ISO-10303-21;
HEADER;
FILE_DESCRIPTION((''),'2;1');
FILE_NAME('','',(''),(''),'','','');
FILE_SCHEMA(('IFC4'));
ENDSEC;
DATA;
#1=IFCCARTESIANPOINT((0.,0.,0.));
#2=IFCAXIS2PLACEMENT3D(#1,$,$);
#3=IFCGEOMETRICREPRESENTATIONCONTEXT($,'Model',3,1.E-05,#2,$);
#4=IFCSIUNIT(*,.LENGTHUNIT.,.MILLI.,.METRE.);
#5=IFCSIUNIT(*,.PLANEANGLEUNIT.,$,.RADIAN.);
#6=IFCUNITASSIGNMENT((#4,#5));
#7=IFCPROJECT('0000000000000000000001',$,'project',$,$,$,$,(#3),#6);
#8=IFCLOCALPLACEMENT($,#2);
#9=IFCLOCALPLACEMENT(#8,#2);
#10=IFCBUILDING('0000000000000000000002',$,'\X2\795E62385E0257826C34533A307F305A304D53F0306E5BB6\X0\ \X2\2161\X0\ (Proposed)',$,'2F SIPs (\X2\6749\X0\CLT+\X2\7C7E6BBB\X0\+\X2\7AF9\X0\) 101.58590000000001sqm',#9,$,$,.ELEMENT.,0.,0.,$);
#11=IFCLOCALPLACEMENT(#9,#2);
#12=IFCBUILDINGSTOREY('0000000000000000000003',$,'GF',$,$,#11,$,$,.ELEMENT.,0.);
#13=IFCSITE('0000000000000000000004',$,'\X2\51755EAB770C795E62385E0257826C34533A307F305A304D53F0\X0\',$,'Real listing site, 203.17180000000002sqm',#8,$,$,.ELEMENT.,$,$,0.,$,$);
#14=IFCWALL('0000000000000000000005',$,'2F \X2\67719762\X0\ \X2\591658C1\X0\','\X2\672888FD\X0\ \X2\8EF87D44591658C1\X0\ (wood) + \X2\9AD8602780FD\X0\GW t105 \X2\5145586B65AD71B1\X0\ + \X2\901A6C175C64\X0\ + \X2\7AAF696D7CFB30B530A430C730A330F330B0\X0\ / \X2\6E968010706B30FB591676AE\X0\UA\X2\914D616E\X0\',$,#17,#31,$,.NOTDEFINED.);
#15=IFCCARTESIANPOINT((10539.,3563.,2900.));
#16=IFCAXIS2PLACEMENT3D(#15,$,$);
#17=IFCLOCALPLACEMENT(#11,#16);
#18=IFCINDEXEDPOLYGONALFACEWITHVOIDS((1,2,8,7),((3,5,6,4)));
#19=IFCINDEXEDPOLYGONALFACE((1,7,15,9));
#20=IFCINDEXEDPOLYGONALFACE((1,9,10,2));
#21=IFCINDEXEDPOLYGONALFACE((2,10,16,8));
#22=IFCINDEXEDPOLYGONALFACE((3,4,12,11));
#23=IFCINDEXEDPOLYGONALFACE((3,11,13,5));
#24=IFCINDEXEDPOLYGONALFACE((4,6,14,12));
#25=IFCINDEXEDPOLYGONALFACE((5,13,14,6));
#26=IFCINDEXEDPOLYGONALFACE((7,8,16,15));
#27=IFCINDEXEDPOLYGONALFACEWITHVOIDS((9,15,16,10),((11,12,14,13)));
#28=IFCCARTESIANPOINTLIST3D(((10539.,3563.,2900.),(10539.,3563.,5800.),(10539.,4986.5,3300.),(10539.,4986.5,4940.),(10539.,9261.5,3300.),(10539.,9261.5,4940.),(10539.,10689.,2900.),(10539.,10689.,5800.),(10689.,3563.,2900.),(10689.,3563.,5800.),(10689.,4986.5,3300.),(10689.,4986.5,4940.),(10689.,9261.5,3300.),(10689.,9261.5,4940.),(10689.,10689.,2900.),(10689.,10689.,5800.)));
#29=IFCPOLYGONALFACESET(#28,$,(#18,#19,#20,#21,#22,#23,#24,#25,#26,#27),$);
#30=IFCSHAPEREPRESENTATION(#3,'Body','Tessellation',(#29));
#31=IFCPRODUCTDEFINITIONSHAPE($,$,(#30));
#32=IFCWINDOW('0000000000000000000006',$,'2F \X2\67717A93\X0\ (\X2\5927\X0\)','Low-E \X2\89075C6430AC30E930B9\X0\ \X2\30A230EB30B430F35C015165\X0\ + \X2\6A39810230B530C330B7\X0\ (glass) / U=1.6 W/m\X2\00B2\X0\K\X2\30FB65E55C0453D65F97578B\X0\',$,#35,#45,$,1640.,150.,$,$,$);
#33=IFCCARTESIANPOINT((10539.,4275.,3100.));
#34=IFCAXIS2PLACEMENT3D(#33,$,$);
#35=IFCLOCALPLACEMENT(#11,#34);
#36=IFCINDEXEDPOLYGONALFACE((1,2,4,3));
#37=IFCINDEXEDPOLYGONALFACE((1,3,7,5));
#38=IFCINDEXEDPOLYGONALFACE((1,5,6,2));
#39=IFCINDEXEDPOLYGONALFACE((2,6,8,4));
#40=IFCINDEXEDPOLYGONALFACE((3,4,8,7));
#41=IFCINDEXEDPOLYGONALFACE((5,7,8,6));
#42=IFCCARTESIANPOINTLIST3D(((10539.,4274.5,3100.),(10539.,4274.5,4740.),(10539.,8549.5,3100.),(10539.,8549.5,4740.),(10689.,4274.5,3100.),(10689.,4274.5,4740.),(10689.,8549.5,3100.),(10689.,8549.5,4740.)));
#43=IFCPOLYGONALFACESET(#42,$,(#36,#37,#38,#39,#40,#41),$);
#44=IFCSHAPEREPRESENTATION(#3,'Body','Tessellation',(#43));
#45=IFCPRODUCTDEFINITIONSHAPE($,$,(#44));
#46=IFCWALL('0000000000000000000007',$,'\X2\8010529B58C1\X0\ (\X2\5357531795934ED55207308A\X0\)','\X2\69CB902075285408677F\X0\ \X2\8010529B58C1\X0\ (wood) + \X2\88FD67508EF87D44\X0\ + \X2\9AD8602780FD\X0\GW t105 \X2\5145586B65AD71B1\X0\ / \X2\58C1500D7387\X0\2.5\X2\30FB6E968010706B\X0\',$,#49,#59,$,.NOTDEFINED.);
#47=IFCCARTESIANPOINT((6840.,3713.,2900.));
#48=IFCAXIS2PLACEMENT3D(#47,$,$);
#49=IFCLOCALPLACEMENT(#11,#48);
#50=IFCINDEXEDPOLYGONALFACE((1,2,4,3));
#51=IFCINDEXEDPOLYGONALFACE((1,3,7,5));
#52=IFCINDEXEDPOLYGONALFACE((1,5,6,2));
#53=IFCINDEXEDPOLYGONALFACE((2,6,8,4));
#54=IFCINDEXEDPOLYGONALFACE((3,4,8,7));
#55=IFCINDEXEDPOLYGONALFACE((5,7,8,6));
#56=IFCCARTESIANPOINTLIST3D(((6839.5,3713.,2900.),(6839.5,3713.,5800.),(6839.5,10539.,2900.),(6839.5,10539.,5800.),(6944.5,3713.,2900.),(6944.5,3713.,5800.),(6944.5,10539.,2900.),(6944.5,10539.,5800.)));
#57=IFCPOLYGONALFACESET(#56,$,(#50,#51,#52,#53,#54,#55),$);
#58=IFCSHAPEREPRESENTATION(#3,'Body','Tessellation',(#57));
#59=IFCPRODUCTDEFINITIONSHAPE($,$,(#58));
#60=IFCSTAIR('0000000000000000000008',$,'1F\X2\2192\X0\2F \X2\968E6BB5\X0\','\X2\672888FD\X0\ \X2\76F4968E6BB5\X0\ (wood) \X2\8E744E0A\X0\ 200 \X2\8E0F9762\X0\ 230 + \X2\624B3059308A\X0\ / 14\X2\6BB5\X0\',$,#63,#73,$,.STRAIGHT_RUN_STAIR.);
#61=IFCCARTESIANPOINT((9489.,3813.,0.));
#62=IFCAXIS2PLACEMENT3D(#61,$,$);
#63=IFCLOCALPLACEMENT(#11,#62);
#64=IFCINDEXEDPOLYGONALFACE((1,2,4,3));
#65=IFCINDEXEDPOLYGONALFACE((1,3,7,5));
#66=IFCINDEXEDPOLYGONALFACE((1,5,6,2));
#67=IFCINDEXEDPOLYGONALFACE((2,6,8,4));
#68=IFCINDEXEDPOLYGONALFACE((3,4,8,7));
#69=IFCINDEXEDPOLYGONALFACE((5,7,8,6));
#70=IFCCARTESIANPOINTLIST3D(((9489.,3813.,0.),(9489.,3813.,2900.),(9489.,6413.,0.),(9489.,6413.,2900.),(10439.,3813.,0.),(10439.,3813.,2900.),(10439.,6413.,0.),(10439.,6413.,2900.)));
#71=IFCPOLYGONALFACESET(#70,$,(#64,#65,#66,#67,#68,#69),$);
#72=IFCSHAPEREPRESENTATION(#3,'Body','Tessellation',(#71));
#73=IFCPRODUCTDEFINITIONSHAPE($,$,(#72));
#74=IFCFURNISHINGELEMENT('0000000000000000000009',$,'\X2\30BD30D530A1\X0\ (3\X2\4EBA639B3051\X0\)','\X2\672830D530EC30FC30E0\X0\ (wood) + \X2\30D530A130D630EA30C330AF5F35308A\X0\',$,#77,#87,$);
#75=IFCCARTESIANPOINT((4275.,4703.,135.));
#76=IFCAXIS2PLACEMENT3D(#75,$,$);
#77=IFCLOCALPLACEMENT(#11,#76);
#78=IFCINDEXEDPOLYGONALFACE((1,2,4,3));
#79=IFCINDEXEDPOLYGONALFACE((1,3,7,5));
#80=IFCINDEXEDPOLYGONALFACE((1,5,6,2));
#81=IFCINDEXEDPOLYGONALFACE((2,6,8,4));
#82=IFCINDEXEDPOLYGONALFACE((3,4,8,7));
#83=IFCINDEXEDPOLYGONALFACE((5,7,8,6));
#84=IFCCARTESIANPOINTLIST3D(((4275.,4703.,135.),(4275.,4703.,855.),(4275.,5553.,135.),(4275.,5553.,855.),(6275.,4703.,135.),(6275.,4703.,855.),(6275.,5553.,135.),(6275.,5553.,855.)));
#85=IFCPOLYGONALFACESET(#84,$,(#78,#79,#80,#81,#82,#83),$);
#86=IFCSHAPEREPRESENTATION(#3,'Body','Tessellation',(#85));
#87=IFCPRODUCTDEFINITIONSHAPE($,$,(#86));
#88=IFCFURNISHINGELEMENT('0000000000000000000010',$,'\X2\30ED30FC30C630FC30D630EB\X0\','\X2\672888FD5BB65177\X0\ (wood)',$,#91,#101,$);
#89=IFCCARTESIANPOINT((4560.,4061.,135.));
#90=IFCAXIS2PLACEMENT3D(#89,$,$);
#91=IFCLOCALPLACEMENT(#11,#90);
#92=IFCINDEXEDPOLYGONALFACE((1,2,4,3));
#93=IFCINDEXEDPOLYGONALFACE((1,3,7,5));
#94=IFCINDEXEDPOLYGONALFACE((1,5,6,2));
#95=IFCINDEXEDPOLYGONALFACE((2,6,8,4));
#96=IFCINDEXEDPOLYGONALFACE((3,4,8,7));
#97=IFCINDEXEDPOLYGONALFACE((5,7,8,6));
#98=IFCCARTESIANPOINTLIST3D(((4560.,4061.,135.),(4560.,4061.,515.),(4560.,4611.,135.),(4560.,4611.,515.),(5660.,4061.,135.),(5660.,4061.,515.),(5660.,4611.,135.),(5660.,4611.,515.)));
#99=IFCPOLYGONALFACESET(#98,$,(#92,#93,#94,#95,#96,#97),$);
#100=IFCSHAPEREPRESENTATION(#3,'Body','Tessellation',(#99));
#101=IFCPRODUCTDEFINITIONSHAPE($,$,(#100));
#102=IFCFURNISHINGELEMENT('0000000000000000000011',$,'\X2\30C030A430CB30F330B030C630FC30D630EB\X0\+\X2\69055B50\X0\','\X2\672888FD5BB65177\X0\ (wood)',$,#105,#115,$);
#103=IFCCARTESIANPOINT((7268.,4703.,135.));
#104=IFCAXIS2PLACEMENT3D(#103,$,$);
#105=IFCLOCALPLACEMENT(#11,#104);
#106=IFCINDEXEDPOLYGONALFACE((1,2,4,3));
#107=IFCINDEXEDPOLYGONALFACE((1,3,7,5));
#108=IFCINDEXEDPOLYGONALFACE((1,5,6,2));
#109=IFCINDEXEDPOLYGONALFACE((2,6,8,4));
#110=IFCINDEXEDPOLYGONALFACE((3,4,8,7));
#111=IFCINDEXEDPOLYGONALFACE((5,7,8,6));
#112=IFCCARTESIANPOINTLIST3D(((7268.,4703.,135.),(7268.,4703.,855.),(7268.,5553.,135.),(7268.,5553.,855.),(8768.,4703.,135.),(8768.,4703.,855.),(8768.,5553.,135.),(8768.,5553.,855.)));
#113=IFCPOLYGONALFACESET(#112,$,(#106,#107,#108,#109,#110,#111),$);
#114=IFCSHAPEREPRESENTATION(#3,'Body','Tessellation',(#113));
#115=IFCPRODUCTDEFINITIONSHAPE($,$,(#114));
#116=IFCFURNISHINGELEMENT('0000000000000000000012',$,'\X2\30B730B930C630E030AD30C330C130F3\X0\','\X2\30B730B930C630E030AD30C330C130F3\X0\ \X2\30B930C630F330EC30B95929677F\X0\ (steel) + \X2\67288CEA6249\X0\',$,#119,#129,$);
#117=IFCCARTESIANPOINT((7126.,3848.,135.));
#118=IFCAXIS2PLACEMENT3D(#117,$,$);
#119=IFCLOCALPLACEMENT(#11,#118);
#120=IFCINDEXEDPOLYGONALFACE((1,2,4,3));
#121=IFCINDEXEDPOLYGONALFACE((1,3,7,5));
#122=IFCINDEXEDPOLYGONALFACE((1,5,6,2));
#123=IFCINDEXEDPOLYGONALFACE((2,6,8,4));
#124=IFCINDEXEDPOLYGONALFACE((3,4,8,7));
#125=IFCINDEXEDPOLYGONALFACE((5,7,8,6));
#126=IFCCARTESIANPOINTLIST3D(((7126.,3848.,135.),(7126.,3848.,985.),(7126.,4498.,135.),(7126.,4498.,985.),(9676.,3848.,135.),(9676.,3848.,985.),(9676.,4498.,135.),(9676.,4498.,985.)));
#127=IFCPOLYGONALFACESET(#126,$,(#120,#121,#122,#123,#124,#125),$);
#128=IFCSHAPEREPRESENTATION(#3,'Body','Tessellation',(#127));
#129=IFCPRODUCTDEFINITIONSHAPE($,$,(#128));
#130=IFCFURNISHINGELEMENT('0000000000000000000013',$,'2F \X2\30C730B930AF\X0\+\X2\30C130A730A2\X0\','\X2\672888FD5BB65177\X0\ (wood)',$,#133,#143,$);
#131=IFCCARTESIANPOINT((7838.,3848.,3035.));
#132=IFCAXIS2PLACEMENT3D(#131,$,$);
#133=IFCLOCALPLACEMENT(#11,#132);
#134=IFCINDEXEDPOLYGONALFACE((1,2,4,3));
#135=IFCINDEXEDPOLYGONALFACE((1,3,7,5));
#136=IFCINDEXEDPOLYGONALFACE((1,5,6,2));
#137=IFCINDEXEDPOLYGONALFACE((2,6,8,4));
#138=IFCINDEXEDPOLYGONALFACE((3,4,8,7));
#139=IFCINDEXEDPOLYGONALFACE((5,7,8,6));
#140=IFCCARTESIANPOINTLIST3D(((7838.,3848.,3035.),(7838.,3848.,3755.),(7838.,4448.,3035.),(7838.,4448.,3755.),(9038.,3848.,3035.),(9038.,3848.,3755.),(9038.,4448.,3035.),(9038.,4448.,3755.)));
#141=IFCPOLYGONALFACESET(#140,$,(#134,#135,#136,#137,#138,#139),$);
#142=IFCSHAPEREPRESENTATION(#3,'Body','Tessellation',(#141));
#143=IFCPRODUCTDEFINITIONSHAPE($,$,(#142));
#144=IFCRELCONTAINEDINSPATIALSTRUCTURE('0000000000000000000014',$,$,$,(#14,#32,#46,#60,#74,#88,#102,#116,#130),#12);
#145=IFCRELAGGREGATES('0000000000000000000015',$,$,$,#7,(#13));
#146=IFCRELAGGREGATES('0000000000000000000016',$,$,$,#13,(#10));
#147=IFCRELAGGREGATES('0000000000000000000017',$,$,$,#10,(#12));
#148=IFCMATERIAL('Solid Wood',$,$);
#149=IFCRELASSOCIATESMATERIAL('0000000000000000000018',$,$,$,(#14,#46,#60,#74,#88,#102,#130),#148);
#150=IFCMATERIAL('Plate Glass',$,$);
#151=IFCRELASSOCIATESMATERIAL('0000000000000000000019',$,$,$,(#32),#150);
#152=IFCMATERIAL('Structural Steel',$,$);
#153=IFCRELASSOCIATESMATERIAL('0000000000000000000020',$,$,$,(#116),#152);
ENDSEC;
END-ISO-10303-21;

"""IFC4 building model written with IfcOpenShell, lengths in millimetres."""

from ifc_helpers import new_model, si_unit, frame, frame_2d, origin, place, context, project, spatial, rectangle, extrude, material, element, fill, save


model = new_model("IFC4")

# Units and contexts
model_context = context("Model", 3, precision=1e-05, world=origin())
ifc_project = project(units=[si_unit("LENGTHUNIT", "METRE", prefix="MILLI"), si_unit("PLANEANGLEUNIT", "RADIAN")], contexts=[model_context])

# Site, building, storey
site_placement = place(None, origin())
site = spatial("IfcSite", under=ifc_project, at=site_placement, Name="兵庫県神戸市垂水区みずき台", ObjectType="Real listing site, 203.17180000000002sqm", CompositionType="ELEMENT", RefElevation=0.0)
building_placement = place(site_placement, origin())
building = spatial("IfcBuilding", under=site, at=building_placement, Name="神戸市垂水区みずき台の家 Ⅱ (Proposed)", ObjectType="2F SIPs (杉CLT+籾殻+竹) 101.58590000000001sqm", CompositionType="ELEMENT", ElevationOfRefHeight=0.0, ElevationOfTerrain=0.0)
storey_placement = place(building_placement, origin())
storey = spatial("IfcBuildingStorey", under=building, at=storey_placement, Name="GF", CompositionType="ELEMENT", Elevation=0.0)

# Shared definitions
ifc_material_1 = material(Name="Solid Wood")
ifc_material_2 = material(Name="Plate Glass")

# Wall, opening, window
wall_1_placement = place(storey_placement, frame((10539.0, 3563.0, 2900.0)))
wall_1 = element("IfcWall", 1, at=wall_1_placement, inside=storey, material=ifc_material_1, Name="2F 東面 外壁", Description="木製 軸組外壁 (wood) + 高性能GW t105 充填断熱 + 通気層 + 窯業系サイディング / 準耐火・外皮UA配慮", PredefinedType="NOTDEFINED", context=model_context, shape_type="SweptSolid", body=[
    extrude(rectangle(XDim=150.0, YDim=7126.0, at=frame_2d((75.0, 3563.0))), frame((10539.0, 3563.0, 2900.0)), (0.0, 0.0, 1.0), 2900.0),
])
opening_1_placement = place(storey_placement, frame((10539.0, 4275.0, 3100.0)))
opening_1 = element("IfcOpeningElement", 2, at=opening_1_placement, cuts=wall_1, PredefinedType="NOTDEFINED", context=model_context, shape_type="SweptSolid", body=[
    extrude(rectangle(XDim=150.0, YDim=4275.0, at=frame_2d((75.0, 2137.0))), frame((10539.0, 4275.0, 3100.0)), (0.0, 0.0, 1.0), 1640.0),
])
window_1_placement = place(storey_placement, frame((10539.0, 4275.0, 3100.0)))
window_1 = element("IfcWindow", 3, at=window_1_placement, inside=storey, material=ifc_material_2, Name="2F 東窓 (大)", Description="Low-E 複層ガラス アルゴン封入 + 樹脂サッシ (glass) / U=1.6 W/m²K・日射取得型", OverallHeight=1640.0, OverallWidth=150.0, context=model_context, shape_type="SweptSolid", body=[
    extrude(rectangle(XDim=150.0, YDim=4275.0, at=frame_2d((75.0, 2137.0))), frame((10539.0, 4275.0, 3100.0)), (0.0, 0.0, 1.0), 1640.0),
])
fill(opening_1, window_1)

# Wall
wall_2_placement = place(storey_placement, frame((6840.0, 3713.0, 2900.0)))
element("IfcWall", 4, at=wall_2_placement, inside=storey, material=ifc_material_1, Name="耐力壁 (南北間仕切り)", Description="構造用合板 耐力壁 (wood) + 製材軸組 + 高性能GW t105 充填断熱 / 壁倍率2.5・準耐火", PredefinedType="NOTDEFINED", context=model_context, shape_type="SweptSolid", body=[
    extrude(rectangle(XDim=105.0, YDim=6826.0, at=frame_2d((52.0, 3413.0))), frame((6840.0, 3713.0, 2900.0)), (0.0, 0.0, 1.0), 2900.0),
])

# Stair
stair_placement = place(storey_placement, frame((9489.0, 3813.0, 0.0)))
element("IfcStair", 5, at=stair_placement, inside=storey, material=ifc_material_1, Name="1F→2F 階段", Description="木製 直階段 (wood) 蹴上 200 踏面 230 + 手すり / 14段", PredefinedType="STRAIGHT_RUN_STAIR", context=model_context, shape_type="SweptSolid", body=[
    extrude(rectangle(XDim=950.0, YDim=2600.0, at=frame_2d((475.0, 1300.0))), frame((9489.0, 3813.0, 0.0)), (0.0, 0.0, 1.0), 2900.0),
])

# Furnishing elements
furnishing_1_placement = place(storey_placement, frame((4275.0, 4703.0, 135.0)))
element("IfcFurnishingElement", 6, at=furnishing_1_placement, inside=storey, material=ifc_material_1, Name="ソファ (3人掛け)", Description="木フレーム (wood) + ファブリック張り", context=model_context, shape_type="SweptSolid", body=[
    extrude(rectangle(XDim=2000.0, YDim=850.0, at=frame_2d((1000.0, 425.0))), frame((4275.0, 4703.0, 135.0)), (0.0, 0.0, 1.0), 720.0),
])
furnishing_2_placement = place(storey_placement, frame((4560.0, 4061.0, 135.0)))
element("IfcFurnishingElement", 7, at=furnishing_2_placement, inside=storey, material=ifc_material_1, Name="ローテーブル", Description="木製家具 (wood)", context=model_context, shape_type="SweptSolid", body=[
    extrude(rectangle(XDim=1100.0, YDim=550.0, at=frame_2d((550.0, 275.0))), frame((4560.0, 4061.0, 135.0)), (0.0, 0.0, 1.0), 380.0),
])
furnishing_3_placement = place(storey_placement, frame((7268.0, 4703.0, 135.0)))
element("IfcFurnishingElement", 8, at=furnishing_3_placement, inside=storey, material=ifc_material_1, Name="ダイニングテーブル+椅子", Description="木製家具 (wood)", context=model_context, shape_type="SweptSolid", body=[
    extrude(rectangle(XDim=1500.0, YDim=850.0, at=frame_2d((750.0, 425.0))), frame((7268.0, 4703.0, 135.0)), (0.0, 0.0, 1.0), 720.0),
])
ifc_material_3 = material(Name="Structural Steel")
furnishing_4_placement = place(storey_placement, frame((7126.0, 3848.0, 135.0)))
element("IfcFurnishingElement", 9, at=furnishing_4_placement, inside=storey, material=ifc_material_3, Name="システムキッチン", Description="システムキッチン ステンレス天板 (steel) + 木質扉", context=model_context, shape_type="SweptSolid", body=[
    extrude(rectangle(XDim=2550.0, YDim=650.0, at=frame_2d((1275.0, 325.0))), frame((7126.0, 3848.0, 135.0)), (0.0, 0.0, 1.0), 850.0),
])
furnishing_5_placement = place(storey_placement, frame((7838.0, 3848.0, 3035.0)))
element("IfcFurnishingElement", 10, at=furnishing_5_placement, inside=storey, material=ifc_material_1, Name="2F デスク+チェア", Description="木製家具 (wood)", context=model_context, shape_type="SweptSolid", body=[
    extrude(rectangle(XDim=1200.0, YDim=600.0, at=frame_2d((600.0, 300.0))), frame((7838.0, 3848.0, 3035.0)), (0.0, 0.0, 1.0), 720.0),
])

save(model, "model.ifc")
